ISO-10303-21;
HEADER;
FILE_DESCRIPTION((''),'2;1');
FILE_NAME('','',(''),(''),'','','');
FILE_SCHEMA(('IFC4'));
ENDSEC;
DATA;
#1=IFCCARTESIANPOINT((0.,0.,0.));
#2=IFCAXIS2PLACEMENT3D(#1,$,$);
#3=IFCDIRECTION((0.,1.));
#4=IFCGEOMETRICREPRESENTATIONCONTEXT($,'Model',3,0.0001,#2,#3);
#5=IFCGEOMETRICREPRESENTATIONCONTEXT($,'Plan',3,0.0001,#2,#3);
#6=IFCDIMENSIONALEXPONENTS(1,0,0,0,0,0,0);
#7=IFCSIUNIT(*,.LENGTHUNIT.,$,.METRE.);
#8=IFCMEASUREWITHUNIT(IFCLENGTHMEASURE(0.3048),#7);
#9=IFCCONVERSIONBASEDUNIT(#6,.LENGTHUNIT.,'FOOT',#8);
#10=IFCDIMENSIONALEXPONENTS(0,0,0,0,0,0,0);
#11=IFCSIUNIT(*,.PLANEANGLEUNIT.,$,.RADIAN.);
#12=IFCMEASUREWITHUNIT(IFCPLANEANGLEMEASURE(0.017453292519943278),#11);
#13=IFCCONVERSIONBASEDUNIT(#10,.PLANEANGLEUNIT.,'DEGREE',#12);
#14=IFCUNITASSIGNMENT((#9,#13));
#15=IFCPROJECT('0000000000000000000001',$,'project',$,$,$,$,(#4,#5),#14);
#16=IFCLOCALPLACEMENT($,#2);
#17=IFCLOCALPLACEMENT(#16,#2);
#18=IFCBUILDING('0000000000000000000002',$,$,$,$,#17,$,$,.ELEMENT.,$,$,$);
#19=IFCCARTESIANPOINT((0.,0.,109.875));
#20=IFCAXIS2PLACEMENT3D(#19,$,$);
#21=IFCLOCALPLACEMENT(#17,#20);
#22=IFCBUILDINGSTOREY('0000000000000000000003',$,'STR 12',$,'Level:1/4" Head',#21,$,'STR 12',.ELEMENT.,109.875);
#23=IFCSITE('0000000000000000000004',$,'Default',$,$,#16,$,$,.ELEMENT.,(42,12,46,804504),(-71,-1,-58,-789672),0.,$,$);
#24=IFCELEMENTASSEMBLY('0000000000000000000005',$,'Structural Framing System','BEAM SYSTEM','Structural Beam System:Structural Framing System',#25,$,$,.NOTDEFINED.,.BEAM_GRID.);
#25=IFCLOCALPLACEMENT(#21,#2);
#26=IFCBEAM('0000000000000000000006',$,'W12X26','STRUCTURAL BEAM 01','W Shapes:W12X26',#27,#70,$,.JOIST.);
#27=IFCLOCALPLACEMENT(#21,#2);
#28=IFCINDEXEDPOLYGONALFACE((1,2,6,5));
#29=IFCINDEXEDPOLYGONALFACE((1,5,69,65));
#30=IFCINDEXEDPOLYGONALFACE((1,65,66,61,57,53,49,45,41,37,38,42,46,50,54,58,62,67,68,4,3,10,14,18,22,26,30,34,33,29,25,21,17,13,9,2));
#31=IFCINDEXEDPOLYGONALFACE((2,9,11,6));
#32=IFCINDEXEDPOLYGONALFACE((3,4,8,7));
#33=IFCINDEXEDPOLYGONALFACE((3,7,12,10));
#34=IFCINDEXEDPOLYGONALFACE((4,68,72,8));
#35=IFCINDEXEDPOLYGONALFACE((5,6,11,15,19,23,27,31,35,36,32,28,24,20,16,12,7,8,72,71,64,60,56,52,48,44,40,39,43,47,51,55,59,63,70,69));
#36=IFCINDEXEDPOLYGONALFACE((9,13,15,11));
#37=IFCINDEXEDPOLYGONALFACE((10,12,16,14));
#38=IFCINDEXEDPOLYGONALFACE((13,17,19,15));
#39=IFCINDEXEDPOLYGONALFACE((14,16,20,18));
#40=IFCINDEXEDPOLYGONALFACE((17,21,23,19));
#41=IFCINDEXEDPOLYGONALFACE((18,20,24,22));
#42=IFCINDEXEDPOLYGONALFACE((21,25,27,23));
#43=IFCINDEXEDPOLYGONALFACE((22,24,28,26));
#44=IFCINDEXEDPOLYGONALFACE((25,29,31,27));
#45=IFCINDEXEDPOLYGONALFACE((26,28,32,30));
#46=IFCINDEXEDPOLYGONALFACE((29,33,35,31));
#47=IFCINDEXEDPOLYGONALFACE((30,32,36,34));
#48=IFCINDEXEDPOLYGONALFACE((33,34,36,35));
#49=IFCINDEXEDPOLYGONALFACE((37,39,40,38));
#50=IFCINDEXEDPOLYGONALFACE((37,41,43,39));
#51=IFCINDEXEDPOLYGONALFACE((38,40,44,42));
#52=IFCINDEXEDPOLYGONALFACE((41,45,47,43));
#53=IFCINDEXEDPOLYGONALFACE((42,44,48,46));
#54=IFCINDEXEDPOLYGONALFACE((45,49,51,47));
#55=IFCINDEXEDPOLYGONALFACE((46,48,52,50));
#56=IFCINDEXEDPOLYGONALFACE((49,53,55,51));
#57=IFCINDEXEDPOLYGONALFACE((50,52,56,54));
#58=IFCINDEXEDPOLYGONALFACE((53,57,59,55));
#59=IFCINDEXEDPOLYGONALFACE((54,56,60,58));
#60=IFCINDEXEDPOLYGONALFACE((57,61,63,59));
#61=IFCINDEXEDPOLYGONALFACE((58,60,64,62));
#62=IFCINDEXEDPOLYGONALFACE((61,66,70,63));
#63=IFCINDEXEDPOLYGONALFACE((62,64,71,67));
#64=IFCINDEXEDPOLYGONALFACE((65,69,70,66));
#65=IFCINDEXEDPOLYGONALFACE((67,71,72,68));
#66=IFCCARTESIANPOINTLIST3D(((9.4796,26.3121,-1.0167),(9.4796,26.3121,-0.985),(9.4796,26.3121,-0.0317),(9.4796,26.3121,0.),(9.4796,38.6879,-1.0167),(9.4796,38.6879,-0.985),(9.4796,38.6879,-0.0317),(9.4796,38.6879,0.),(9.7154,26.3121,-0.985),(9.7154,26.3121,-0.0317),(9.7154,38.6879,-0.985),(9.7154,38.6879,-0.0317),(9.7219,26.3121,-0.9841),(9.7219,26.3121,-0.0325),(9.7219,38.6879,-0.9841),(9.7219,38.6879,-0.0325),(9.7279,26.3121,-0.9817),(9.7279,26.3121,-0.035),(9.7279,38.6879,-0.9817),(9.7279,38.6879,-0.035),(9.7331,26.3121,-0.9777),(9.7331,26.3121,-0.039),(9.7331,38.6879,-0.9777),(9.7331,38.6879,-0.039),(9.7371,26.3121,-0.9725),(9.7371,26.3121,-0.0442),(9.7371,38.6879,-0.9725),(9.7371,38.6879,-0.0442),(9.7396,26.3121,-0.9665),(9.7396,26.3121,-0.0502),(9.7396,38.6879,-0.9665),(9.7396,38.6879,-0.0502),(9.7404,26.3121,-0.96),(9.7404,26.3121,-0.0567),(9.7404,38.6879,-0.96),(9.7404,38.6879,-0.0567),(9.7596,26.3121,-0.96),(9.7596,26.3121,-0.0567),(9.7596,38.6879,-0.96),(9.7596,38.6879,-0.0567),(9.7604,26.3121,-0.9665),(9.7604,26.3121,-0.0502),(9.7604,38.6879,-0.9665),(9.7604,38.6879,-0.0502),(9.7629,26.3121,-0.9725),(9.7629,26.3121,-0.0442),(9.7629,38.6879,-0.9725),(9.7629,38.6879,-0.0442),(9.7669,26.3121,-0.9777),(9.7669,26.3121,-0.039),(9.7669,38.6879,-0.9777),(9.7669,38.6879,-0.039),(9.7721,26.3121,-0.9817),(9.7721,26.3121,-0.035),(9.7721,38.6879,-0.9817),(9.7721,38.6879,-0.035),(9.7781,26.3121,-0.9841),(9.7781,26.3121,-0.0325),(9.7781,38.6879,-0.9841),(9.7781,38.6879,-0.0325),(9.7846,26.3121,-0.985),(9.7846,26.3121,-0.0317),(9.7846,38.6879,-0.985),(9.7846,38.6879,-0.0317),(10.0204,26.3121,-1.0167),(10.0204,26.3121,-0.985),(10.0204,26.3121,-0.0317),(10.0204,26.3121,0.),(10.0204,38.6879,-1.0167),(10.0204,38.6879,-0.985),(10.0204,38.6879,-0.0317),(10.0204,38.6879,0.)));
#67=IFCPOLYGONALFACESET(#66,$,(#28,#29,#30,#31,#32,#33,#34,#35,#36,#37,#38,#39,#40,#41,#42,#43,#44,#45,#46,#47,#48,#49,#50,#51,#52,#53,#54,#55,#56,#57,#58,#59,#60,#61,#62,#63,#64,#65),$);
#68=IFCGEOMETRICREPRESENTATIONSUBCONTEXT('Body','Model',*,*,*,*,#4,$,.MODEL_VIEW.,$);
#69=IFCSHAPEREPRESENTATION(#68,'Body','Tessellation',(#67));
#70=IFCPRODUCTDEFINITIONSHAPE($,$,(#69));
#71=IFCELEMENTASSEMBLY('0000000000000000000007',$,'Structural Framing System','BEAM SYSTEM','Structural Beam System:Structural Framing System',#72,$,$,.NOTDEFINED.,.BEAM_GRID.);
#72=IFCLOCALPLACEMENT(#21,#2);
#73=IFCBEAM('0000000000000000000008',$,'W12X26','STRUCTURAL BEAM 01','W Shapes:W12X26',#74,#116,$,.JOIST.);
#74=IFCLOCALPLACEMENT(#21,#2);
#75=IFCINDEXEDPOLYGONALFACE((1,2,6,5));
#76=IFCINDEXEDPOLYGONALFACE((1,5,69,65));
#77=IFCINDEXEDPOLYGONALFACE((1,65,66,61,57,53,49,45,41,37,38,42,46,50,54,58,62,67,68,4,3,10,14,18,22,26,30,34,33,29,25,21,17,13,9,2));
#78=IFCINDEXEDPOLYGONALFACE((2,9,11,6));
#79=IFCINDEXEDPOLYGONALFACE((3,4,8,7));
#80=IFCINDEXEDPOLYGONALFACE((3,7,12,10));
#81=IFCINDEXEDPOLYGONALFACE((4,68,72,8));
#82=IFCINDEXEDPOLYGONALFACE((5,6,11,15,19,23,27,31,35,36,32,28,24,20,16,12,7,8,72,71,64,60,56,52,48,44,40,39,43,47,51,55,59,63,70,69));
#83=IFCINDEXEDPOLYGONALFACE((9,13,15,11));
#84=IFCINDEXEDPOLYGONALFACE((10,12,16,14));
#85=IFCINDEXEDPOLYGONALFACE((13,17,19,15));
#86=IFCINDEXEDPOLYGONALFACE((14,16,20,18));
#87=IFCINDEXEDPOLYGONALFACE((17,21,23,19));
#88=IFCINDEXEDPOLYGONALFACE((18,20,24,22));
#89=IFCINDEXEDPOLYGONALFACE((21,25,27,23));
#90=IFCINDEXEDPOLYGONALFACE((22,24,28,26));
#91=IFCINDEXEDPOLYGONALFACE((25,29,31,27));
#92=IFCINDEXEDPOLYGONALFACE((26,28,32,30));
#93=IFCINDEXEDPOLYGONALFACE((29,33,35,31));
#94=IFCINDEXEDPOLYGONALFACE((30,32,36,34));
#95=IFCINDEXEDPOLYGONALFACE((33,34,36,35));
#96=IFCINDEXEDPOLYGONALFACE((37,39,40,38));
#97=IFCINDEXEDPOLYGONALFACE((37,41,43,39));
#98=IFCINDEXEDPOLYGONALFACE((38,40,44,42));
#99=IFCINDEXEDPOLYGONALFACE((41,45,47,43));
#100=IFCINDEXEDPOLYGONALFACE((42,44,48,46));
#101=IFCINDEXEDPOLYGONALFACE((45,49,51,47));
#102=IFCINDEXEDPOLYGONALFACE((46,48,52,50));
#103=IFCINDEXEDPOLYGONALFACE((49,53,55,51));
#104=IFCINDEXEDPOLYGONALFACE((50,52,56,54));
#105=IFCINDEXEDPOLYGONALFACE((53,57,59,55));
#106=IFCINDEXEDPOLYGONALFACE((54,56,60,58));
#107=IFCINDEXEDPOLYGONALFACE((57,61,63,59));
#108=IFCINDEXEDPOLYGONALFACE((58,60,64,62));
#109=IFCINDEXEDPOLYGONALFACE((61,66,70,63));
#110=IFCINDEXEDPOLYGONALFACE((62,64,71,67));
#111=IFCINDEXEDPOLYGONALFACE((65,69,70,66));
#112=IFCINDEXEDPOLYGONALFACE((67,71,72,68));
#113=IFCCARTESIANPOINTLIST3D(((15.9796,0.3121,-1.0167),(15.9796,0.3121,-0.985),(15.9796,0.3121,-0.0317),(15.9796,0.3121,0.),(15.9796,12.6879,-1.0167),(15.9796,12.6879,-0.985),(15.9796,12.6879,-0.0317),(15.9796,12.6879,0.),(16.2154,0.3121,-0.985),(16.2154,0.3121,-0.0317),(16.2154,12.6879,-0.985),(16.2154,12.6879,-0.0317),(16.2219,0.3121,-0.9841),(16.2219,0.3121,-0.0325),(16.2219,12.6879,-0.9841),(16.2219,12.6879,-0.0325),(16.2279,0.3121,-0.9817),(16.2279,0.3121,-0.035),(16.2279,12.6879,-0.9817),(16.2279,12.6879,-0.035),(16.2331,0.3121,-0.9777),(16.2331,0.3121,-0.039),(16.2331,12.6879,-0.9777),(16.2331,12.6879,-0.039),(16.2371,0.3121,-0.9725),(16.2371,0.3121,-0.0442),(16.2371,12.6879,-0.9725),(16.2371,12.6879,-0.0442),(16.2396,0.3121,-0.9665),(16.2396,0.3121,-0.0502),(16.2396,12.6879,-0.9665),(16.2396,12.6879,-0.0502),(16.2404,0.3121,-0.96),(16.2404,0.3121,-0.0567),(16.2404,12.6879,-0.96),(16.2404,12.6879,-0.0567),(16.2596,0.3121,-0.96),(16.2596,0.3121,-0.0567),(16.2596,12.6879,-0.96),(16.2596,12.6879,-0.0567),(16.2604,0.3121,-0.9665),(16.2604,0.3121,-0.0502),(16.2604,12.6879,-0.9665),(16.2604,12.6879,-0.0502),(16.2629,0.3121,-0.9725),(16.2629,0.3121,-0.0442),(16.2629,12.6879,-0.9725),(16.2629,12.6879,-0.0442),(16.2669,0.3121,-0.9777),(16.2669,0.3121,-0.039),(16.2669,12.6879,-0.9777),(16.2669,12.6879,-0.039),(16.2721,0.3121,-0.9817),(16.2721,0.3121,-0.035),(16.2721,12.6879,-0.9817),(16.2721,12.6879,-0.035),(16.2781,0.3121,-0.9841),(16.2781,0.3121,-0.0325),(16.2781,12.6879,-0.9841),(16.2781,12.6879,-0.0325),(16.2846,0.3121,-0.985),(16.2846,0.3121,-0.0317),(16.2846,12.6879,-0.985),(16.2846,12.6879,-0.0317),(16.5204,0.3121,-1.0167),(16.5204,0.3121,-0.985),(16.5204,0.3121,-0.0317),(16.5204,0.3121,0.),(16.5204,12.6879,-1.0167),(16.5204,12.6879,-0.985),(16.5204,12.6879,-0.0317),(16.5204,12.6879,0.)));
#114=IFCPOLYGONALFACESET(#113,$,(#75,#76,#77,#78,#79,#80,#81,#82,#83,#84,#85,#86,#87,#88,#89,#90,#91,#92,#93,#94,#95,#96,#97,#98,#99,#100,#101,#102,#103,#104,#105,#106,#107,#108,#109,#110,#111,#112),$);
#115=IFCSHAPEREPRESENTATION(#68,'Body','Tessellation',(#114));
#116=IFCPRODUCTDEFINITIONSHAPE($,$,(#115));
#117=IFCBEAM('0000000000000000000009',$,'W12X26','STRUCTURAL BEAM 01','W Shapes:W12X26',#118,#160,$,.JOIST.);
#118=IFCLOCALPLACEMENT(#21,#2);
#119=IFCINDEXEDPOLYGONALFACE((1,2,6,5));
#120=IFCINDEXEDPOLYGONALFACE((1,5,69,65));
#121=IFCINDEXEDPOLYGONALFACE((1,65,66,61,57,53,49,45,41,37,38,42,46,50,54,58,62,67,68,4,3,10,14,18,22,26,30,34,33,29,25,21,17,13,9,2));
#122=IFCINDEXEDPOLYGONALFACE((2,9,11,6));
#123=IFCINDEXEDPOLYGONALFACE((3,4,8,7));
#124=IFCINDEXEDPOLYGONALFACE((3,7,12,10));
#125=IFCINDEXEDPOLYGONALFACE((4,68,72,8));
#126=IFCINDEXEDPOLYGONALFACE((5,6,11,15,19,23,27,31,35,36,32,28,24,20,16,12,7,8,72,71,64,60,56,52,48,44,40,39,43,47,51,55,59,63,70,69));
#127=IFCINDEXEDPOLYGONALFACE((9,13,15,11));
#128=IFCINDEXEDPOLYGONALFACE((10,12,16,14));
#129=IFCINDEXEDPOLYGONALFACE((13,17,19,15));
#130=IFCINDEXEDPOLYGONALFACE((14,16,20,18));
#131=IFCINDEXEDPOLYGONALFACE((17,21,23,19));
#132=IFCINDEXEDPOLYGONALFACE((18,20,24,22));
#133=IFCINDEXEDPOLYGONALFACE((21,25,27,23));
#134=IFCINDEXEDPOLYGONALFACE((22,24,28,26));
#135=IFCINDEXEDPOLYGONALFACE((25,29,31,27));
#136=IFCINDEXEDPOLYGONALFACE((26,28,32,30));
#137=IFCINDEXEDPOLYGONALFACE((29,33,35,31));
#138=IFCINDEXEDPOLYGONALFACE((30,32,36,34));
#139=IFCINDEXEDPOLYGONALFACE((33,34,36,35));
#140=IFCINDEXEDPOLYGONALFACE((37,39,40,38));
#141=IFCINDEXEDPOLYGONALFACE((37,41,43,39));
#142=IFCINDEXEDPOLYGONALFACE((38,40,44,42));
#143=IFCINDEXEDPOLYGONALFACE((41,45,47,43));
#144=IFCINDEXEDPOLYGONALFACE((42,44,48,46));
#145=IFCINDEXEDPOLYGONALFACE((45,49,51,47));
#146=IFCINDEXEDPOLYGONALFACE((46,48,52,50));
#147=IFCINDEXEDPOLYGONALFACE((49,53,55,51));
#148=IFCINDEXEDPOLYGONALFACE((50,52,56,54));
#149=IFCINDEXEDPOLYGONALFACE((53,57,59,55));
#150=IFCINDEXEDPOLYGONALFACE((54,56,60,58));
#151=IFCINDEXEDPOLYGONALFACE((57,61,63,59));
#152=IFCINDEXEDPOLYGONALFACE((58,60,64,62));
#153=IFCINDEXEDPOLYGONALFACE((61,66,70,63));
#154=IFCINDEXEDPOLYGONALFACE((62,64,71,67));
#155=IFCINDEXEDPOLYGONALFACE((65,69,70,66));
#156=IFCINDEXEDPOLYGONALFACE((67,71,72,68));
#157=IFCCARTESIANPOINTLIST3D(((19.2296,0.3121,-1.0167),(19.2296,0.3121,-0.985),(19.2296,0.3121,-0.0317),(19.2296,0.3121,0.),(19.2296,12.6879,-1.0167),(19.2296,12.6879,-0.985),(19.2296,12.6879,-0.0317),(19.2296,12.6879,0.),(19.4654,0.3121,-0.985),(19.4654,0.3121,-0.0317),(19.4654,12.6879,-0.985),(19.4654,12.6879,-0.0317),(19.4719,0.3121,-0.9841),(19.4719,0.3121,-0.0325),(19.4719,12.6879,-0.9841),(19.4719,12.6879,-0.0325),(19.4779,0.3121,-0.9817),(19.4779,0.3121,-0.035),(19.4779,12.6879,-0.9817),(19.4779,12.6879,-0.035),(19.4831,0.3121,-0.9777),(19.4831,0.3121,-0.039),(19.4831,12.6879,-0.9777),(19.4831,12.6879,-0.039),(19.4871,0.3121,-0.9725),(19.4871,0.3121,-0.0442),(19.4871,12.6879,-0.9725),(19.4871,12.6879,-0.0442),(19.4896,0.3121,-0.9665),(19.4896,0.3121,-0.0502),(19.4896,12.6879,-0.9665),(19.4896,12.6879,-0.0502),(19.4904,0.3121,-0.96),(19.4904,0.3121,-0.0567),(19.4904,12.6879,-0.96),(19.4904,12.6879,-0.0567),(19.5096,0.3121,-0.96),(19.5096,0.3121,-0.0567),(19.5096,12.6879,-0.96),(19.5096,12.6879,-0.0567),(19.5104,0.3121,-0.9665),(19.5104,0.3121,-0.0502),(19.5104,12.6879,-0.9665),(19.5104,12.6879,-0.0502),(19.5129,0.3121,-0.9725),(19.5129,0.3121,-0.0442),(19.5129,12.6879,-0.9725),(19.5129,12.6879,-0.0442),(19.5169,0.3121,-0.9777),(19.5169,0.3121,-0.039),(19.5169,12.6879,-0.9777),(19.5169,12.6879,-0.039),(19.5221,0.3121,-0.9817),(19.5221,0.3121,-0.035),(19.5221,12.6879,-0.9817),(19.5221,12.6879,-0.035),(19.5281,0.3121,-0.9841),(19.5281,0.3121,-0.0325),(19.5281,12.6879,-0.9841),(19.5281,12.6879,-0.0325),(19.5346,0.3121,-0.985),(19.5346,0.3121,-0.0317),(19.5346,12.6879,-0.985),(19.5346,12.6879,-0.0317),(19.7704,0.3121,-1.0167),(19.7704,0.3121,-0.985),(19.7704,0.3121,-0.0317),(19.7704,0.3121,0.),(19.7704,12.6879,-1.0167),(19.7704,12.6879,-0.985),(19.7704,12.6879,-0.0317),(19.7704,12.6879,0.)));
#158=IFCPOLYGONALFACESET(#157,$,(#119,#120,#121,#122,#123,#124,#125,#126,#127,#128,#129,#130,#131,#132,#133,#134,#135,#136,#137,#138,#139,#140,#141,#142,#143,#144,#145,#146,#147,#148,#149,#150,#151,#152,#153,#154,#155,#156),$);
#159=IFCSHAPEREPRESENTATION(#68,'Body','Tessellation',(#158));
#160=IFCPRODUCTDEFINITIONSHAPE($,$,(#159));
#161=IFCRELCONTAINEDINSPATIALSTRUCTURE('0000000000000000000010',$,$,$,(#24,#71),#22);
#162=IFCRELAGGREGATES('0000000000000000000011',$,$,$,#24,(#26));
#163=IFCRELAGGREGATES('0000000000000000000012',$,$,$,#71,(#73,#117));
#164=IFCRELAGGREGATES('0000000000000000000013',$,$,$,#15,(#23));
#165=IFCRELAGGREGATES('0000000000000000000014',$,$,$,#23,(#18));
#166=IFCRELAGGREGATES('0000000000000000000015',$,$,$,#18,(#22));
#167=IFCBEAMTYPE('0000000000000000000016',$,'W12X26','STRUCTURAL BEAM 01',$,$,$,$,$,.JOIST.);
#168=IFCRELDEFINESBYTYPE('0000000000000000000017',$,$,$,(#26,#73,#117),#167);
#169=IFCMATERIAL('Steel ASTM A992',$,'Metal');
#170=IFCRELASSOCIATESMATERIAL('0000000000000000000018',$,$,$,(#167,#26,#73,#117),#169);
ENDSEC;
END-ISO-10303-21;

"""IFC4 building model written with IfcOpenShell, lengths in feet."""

from ifc_helpers import new_model, entity, si_unit, converted_unit, direction, frame, origin, place, context, subcontext, project, spatial, line, arc, indexed_curve, outline, extrude, source, transform, mapped, material, type_object, type_shapes, element, aggregate, save


model = new_model("IFC4")

# Units and contexts
model_context = context("Model", 3, precision=0.0001, world=origin(), true_north=direction((0.0, 1.0)))
plan_context = context("Plan", 3, precision=0.0001, world=origin(), true_north=direction((0.0, 1.0)))
body_context = subcontext(model_context, "Body", "Model", "MODEL_VIEW")
ifc_project = project(units=[converted_unit("LENGTHUNIT", "FOOT", entity("IfcLengthMeasure", 0.3048), si_unit("LENGTHUNIT", "METRE"), dimensions=[1, 0, 0, 0, 0, 0, 0]), converted_unit("PLANEANGLEUNIT", "DEGREE", entity("IfcPlaneAngleMeasure", 0.017453292519943278), si_unit("PLANEANGLEUNIT", "RADIAN"), dimensions=[0, 0, 0, 0, 0, 0, 0])], contexts=[model_context, plan_context])

# Site, building, storey
site_placement = place(None, origin())
site = spatial("IfcSite", under=ifc_project, at=site_placement, Name="Default", CompositionType="ELEMENT", RefLatitude=(42, 12, 46, 804504), RefLongitude=(-71, -1, -58, -789672), RefElevation=0.0)
building_placement = place(site_placement, origin())
building = spatial("IfcBuilding", under=site, at=building_placement, CompositionType="ELEMENT")
storey_placement = place(building_placement, frame((0.0, 0.0, 109.875)))
storey = spatial("IfcBuildingStorey", under=building, at=storey_placement, Name="STR 12", ObjectType="Level:1/4\" Head", LongName="STR 12", CompositionType="ELEMENT", Elevation=109.875)

# Element assemblies, beams
ifc_material = material(Name="Steel ASTM A992", Category="Metal")
beam_type = type_object("IfcBeamType", Name="W12X26", Description="STRUCTURAL BEAM 01", PredefinedType="JOIST", material=ifc_material)
shared_shape = source(origin(), body_context, "Body", "SweptSolid", [
    extrude(outline(indexed_curve([(-0.2704, -0.4767), (-0.2704, -0.5083), (0.2704, -0.5083), (0.2704, -0.4767), (0.0346, -0.4767), (0.0169, -0.4693), (0.0096, -0.4517), (0.0096, 0.4517), (0.0169, 0.4693), (0.0346, 0.4767), (0.2704, 0.4767), (0.2704, 0.5083), (-0.2704, 0.5083), (-0.2704, 0.4767), (-0.0346, 0.4767), (-0.0169, 0.4693), (-0.0096, 0.4517), (-0.0096, -0.4517), (-0.0169, -0.4693), (-0.0346, -0.4767)], segments=[line(1, 2, 3, 4, 5), arc(5, 6, 7), line(7, 8), arc(8, 9, 10), line(10, 11, 12, 13, 14, 15), arc(15, 16, 17), line(17, 18), arc(18, 19, 20), line(20, 1)], self_intersect=False)), frame((-6.1879, 0.0, 0.0), z_axis=(-1.0, 0.0, 0.0), x_axis=(0.0, -1.0, 0.0)), (0.0, 0.0, -1.0), 12.3758),
])
type_shapes(beam_type, [shared_shape])
assembly_1_placement = place(storey_placement, origin())
assembly_1 = element("IfcElementAssembly", 1, at=assembly_1_placement, inside=storey, Name="Structural Framing System", Description="BEAM SYSTEM", ObjectType="Structural Beam System:Structural Framing System", AssemblyPlace="NOTDEFINED", PredefinedType="BEAM_GRID")
beam_1_placement = place(assembly_1_placement, frame((9.75, 32.5, -0.5083), z_axis=(0.0, 0.0, 1.0), x_axis=(0.0, 1.0, 0.0)))
beam_1 = element("IfcBeam", 2, at=beam_1_placement, type_object=beam_type, material=ifc_material, Name="W12X26", Description="STRUCTURAL BEAM 01", ObjectType="W Shapes:W12X26", PredefinedType="JOIST", context=body_context, shape_type="MappedRepresentation", body=[
    mapped(shared_shape, transform((0.0, 0.0, 0.0), scale=1.0)),
])
aggregate(assembly_1, [beam_1])
assembly_2_placement = place(storey_placement, origin())
assembly_2 = element("IfcElementAssembly", 3, at=assembly_2_placement, inside=storey, Name="Structural Framing System", Description="BEAM SYSTEM", ObjectType="Structural Beam System:Structural Framing System", AssemblyPlace="NOTDEFINED", PredefinedType="BEAM_GRID")
beam_2_placement = place(assembly_2_placement, frame((16.25, 6.5, -0.5083), z_axis=(0.0, 0.0, 1.0), x_axis=(0.0, 1.0, 0.0)))
beam_2 = element("IfcBeam", 4, at=beam_2_placement, type_object=beam_type, material=ifc_material, Name="W12X26", Description="STRUCTURAL BEAM 01", ObjectType="W Shapes:W12X26", PredefinedType="JOIST", context=body_context, shape_type="MappedRepresentation", body=[
    mapped(shared_shape, transform((0.0, 0.0, 0.0), scale=1.0)),
])
beam_3_placement = place(assembly_2_placement, frame((19.5, 6.5, -0.5083), z_axis=(0.0, 0.0, 1.0), x_axis=(0.0, 1.0, 0.0)))
beam_3 = element("IfcBeam", 5, at=beam_3_placement, type_object=beam_type, material=ifc_material, Name="W12X26", Description="STRUCTURAL BEAM 01", ObjectType="W Shapes:W12X26", PredefinedType="JOIST", context=body_context, shape_type="MappedRepresentation", body=[
    mapped(shared_shape, transform((0.0, 0.0, 0.0), scale=1.0)),
])
aggregate(assembly_2, [beam_2, beam_3])

save(model, "model.ifc")
